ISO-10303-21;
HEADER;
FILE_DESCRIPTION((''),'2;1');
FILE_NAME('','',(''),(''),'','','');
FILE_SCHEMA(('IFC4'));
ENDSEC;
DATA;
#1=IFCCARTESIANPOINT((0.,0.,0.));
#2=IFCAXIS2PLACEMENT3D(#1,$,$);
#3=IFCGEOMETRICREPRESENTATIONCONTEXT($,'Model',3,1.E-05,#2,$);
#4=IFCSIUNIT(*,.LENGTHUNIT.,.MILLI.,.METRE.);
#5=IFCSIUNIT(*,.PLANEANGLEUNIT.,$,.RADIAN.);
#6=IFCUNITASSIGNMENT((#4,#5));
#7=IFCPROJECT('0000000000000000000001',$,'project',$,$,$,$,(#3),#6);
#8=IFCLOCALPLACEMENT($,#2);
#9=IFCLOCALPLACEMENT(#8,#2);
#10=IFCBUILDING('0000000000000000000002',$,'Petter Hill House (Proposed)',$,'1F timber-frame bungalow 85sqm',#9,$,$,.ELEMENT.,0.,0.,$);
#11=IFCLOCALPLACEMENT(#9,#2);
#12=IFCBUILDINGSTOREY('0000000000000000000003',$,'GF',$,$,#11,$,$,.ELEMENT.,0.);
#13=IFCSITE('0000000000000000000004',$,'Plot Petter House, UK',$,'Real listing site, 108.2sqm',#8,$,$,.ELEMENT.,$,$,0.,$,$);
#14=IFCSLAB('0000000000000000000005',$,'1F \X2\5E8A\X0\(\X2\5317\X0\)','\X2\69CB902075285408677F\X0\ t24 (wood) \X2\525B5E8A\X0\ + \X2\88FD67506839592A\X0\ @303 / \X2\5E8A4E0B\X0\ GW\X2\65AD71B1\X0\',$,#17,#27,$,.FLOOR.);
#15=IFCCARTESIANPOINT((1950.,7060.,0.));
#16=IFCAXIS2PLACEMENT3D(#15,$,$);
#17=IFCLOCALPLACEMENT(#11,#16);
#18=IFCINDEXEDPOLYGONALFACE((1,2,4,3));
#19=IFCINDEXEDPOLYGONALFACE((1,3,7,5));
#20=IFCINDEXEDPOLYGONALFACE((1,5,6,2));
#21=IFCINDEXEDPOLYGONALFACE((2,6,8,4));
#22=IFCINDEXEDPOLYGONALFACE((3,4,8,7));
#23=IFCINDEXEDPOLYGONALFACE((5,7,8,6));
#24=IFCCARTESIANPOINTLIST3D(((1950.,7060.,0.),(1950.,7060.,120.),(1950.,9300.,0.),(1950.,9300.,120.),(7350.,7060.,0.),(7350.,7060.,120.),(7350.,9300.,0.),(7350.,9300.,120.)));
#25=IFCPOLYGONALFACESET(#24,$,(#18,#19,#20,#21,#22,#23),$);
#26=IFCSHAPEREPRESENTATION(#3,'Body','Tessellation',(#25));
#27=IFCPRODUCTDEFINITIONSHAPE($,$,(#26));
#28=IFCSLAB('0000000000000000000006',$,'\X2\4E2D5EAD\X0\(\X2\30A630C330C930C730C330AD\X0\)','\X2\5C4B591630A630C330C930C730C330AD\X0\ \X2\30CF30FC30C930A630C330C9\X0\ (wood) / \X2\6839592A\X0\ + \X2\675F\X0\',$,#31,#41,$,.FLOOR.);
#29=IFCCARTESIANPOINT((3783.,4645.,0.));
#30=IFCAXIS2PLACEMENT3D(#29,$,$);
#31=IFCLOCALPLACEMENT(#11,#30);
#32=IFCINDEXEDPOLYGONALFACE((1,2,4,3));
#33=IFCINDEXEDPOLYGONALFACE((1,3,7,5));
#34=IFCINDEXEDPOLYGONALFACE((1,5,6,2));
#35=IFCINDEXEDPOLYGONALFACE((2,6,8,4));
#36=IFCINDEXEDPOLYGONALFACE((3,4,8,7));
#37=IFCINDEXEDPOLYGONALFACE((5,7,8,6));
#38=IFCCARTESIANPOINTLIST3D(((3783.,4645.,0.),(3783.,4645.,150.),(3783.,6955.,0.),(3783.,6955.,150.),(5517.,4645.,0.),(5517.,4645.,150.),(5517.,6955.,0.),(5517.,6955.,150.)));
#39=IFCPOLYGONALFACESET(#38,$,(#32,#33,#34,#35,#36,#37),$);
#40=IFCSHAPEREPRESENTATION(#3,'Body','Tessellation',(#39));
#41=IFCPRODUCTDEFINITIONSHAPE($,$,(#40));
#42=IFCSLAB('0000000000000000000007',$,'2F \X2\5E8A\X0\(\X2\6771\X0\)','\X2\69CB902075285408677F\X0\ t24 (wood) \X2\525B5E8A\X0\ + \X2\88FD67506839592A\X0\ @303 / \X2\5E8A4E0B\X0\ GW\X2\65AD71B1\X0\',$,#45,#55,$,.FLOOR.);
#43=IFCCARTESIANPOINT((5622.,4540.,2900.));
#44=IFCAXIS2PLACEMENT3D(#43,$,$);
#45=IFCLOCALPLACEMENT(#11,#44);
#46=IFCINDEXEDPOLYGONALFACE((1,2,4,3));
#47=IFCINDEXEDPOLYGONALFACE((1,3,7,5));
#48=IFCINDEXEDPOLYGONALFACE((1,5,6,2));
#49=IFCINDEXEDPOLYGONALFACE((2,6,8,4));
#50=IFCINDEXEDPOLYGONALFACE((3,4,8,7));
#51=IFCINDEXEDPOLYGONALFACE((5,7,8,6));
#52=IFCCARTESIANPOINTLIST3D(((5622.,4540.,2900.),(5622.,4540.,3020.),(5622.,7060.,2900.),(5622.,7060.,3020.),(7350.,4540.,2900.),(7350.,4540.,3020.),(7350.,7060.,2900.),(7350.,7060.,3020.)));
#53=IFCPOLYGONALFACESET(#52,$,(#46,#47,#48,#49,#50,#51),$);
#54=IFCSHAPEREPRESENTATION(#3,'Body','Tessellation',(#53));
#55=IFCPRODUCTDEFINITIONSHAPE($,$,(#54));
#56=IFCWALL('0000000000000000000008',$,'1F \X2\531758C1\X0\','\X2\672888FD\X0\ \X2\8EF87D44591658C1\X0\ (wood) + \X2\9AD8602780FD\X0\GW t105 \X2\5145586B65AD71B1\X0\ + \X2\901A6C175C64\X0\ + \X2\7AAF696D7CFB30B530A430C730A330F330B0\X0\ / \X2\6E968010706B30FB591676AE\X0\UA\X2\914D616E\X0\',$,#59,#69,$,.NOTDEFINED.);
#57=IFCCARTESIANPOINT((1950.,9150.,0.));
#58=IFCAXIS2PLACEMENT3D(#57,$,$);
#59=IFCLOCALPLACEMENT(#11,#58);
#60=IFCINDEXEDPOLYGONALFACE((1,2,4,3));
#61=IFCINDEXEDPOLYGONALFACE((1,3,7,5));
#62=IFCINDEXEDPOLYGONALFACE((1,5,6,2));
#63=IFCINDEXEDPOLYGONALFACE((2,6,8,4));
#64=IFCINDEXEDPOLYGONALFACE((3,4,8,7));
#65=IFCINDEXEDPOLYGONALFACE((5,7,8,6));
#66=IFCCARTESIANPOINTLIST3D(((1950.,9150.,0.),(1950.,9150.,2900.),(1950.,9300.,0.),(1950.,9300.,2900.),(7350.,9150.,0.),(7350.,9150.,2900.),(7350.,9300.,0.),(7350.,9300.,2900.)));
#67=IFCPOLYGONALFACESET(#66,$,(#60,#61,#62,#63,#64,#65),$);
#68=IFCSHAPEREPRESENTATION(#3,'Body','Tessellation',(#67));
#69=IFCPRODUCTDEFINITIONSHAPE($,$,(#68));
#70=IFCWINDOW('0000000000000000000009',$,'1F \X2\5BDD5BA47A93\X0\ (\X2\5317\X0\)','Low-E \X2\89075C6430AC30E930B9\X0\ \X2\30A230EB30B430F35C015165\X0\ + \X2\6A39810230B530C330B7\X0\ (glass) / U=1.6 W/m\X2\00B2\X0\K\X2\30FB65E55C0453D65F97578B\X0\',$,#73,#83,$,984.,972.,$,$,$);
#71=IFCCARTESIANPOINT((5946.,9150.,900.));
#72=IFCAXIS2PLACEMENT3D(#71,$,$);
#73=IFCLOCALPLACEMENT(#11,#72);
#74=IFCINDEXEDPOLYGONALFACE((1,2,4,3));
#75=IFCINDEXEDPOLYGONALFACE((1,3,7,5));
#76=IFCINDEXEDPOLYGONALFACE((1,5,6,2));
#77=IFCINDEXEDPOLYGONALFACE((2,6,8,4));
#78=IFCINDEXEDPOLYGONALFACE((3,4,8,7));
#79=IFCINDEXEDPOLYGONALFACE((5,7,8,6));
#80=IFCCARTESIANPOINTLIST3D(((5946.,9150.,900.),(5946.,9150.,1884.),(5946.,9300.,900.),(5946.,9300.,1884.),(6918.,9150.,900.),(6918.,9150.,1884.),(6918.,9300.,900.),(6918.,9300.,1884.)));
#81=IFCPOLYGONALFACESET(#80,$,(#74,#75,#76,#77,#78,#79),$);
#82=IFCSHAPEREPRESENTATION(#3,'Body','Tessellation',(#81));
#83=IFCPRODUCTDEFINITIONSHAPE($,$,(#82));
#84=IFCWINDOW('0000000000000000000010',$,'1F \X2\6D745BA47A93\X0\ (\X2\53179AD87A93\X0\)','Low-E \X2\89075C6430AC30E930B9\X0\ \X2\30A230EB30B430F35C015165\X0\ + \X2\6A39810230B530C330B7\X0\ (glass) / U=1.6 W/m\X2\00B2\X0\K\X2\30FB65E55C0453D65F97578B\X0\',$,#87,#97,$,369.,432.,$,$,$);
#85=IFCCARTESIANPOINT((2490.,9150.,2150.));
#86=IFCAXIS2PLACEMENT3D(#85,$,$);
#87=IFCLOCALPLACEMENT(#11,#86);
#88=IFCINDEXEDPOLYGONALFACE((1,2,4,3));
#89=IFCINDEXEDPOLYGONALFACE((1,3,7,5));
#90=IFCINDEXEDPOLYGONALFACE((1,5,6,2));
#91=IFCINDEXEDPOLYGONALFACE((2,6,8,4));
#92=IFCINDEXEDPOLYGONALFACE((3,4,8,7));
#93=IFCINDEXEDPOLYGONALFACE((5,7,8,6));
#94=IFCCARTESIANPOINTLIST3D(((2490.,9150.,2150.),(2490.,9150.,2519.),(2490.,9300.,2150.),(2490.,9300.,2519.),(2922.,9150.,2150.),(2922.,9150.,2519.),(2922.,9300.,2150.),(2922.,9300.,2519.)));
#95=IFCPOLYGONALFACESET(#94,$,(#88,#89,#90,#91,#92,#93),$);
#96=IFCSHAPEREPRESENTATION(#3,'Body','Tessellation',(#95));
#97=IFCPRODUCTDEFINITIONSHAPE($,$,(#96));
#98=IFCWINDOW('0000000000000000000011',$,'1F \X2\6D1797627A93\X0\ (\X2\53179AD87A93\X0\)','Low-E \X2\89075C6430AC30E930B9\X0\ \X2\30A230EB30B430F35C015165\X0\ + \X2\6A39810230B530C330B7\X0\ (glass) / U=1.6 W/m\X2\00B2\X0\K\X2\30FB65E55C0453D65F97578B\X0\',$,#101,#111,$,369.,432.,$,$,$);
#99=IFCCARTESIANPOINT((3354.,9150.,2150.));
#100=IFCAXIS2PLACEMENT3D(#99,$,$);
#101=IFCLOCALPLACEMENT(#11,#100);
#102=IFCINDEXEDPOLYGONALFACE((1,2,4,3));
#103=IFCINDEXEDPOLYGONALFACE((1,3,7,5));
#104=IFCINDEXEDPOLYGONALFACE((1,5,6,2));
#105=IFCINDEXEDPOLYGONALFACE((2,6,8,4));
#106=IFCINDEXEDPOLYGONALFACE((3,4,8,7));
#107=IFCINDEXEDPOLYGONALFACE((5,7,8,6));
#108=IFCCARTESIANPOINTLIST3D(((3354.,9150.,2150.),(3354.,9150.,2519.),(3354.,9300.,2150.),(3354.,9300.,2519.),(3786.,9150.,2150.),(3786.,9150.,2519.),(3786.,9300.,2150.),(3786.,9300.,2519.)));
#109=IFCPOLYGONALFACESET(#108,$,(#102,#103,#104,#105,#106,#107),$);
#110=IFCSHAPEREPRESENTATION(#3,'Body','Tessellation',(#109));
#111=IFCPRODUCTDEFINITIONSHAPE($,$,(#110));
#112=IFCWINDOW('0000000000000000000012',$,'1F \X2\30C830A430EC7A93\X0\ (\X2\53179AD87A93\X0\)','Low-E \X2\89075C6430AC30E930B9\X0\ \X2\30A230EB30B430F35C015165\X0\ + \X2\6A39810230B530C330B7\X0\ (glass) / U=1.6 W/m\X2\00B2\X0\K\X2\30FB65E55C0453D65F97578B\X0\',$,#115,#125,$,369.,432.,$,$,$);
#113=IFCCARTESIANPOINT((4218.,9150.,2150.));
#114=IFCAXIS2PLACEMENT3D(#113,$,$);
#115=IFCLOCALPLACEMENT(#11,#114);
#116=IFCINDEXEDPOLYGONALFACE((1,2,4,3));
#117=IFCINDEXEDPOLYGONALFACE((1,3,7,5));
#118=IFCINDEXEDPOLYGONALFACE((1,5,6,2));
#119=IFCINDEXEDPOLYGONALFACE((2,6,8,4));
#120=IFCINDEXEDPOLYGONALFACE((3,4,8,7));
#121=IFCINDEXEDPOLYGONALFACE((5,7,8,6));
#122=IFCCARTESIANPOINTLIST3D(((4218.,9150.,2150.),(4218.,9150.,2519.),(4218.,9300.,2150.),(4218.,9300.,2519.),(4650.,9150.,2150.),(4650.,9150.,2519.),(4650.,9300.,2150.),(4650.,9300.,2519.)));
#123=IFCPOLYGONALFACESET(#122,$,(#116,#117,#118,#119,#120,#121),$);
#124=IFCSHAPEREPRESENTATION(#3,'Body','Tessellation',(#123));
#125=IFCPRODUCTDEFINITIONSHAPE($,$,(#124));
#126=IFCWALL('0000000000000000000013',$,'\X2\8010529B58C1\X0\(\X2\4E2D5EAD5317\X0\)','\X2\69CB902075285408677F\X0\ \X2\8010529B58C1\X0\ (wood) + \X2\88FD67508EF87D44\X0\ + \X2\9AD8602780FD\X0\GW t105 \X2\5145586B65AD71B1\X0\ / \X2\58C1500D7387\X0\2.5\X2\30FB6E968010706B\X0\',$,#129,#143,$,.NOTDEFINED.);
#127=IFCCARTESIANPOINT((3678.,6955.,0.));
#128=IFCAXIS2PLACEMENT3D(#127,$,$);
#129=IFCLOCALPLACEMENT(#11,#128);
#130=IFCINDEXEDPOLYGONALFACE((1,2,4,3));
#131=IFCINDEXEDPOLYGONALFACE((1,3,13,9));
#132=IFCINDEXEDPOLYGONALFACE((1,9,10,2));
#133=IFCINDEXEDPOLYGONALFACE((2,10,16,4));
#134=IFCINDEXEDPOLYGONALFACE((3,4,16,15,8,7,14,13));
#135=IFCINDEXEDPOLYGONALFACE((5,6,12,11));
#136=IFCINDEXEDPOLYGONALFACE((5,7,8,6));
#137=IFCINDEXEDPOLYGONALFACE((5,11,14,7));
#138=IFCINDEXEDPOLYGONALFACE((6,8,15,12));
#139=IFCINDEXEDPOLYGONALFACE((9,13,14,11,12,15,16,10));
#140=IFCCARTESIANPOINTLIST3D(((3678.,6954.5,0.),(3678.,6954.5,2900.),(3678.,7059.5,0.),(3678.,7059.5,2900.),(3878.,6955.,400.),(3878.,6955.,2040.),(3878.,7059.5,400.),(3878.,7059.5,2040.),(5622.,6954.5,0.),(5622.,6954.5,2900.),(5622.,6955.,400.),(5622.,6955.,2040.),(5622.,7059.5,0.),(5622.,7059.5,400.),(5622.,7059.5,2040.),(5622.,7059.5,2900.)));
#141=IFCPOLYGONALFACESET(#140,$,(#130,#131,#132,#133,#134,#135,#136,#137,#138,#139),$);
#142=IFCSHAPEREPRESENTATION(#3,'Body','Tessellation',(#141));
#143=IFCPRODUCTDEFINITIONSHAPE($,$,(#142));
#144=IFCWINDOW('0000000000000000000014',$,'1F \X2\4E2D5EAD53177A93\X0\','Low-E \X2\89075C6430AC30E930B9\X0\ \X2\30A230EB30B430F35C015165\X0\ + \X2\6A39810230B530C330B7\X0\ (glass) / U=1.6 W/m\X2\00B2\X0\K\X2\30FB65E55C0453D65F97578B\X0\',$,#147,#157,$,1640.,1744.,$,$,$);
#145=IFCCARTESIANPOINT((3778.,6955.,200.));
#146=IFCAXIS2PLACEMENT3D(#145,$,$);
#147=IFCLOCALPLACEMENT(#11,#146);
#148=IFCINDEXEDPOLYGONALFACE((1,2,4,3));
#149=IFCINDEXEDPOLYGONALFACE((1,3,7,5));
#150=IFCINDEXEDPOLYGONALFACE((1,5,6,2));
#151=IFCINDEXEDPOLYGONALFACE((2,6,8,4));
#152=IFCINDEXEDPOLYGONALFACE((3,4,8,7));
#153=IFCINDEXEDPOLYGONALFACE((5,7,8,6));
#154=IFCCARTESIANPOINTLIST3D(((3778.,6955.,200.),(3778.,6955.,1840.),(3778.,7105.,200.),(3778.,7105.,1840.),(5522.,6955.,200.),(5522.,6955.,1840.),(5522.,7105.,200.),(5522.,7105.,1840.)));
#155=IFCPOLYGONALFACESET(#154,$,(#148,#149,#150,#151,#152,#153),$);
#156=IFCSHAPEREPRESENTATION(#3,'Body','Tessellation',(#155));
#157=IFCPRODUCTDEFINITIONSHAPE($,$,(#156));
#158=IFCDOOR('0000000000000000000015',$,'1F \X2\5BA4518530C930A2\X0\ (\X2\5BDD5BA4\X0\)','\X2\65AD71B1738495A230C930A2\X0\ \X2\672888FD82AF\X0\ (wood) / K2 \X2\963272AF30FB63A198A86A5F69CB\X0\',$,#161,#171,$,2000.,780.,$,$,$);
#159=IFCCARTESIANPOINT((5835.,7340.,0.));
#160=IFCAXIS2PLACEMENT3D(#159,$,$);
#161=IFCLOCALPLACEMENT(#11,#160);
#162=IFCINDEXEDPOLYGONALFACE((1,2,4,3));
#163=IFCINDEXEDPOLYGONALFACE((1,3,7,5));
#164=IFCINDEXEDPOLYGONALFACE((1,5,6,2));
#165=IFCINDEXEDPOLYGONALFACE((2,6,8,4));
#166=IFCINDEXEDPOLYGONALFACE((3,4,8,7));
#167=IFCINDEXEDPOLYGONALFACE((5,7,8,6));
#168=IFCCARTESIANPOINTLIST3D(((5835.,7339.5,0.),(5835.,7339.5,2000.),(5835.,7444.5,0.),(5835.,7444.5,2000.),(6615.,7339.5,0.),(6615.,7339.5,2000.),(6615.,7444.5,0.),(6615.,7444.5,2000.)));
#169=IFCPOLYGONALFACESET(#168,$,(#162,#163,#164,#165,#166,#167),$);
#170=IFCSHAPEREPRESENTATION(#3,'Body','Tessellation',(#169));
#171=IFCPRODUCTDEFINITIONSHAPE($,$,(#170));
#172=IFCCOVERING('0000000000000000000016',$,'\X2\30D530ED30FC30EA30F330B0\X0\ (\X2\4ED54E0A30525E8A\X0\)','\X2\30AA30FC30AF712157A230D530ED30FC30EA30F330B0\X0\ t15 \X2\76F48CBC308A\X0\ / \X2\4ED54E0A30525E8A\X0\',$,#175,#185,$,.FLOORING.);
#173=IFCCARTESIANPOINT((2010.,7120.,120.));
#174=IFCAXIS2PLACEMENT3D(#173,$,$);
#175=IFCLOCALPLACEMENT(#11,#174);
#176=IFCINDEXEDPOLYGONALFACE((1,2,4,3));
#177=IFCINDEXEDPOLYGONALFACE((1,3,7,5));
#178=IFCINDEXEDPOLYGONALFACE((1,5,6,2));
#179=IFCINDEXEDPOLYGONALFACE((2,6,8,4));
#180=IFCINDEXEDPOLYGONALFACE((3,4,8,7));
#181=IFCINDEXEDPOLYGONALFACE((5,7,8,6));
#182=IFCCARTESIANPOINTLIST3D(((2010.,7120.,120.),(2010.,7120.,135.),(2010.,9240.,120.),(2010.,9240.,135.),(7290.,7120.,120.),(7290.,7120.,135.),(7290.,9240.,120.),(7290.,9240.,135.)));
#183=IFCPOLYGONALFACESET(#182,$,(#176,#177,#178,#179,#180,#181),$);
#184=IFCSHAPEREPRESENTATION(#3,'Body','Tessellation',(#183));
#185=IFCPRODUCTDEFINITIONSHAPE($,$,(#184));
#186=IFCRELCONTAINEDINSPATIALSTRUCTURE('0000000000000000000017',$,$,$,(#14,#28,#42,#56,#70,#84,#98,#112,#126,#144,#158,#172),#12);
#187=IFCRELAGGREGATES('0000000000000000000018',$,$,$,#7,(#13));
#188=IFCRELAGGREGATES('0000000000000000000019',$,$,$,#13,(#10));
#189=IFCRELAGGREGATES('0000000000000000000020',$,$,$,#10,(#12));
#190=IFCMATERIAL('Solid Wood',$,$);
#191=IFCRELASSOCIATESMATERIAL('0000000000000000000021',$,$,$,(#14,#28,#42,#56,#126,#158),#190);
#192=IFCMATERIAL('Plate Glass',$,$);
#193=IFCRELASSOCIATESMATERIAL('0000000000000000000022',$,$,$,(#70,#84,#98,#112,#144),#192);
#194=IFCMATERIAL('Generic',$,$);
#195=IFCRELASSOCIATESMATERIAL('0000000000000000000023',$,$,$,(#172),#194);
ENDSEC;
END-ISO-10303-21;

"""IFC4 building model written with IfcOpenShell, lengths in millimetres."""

from ifc_helpers import new_model, si_unit, frame, frame_2d, origin, place, context, project, spatial, rectangle, extrude, material, element, fill, save


model = new_model("IFC4")

# Units and contexts
model_context = context("Model", 3, precision=1e-05, world=origin())
ifc_project = project(units=[si_unit("LENGTHUNIT", "METRE", prefix="MILLI"), si_unit("PLANEANGLEUNIT", "RADIAN")], contexts=[model_context])

# Site, building, storey
site_placement = place(None, origin())
site = spatial("IfcSite", under=ifc_project, at=site_placement, Name="Plot Petter House, UK", ObjectType="Real listing site, 108.2sqm", CompositionType="ELEMENT", RefElevation=0.0)
building_placement = place(site_placement, origin())
building = spatial("IfcBuilding", under=site, at=building_placement, Name="Petter Hill House (Proposed)", ObjectType="1F timber-frame bungalow 85sqm", CompositionType="ELEMENT", ElevationOfRefHeight=0.0, ElevationOfTerrain=0.0)
storey_placement = place(building_placement, origin())
storey = spatial("IfcBuildingStorey", under=building, at=storey_placement, Name="GF", CompositionType="ELEMENT", Elevation=0.0)

# Slabs
ifc_material_1 = material(Name="Solid Wood")
slab_1_placement = place(storey_placement, frame((1950.0, 7060.0, 0.0)))
element("IfcSlab", 1, at=slab_1_placement, inside=storey, material=ifc_material_1, Name="1F 床(北)", Description="構造用合板 t24 (wood) 剛床 + 製材根太 @303 / 床下 GW断熱", PredefinedType="FLOOR", context=model_context, shape_type="SweptSolid", body=[
    extrude(rectangle(XDim=5400.0, YDim=2240.0, at=frame_2d((2700.0, 1120.0))), frame((1950.0, 7060.0, 0.0)), (0.0, 0.0, 1.0), 120.0),
])
slab_2_placement = place(storey_placement, frame((3783.0, 4645.0, 0.0)))
element("IfcSlab", 2, at=slab_2_placement, inside=storey, material=ifc_material_1, Name="中庭(ウッドデッキ)", Description="屋外ウッドデッキ ハードウッド (wood) / 根太 + 束", PredefinedType="FLOOR", context=model_context, shape_type="SweptSolid", body=[
    extrude(rectangle(XDim=1734.0, YDim=2310.0, at=frame_2d((867.0, 1155.0))), frame((3783.0, 4645.0, 0.0)), (0.0, 0.0, 1.0), 150.0),
])
slab_3_placement = place(storey_placement, frame((5622.0, 4540.0, 2900.0)))
element("IfcSlab", 3, at=slab_3_placement, inside=storey, material=ifc_material_1, Name="2F 床(東)", Description="構造用合板 t24 (wood) 剛床 + 製材根太 @303 / 床下 GW断熱", PredefinedType="FLOOR", context=model_context, shape_type="SweptSolid", body=[
    extrude(rectangle(XDim=1728.0, YDim=2520.0, at=frame_2d((864.0, 1260.0))), frame((5622.0, 4540.0, 2900.0)), (0.0, 0.0, 1.0), 120.0),
])

# Wall, openings, windows
wall_1_placement = place(storey_placement, frame((1950.0, 9150.0, 0.0)))
wall_1 = element("IfcWall", 4, at=wall_1_placement, inside=storey, material=ifc_material_1, Name="1F 北壁", Description="木製 軸組外壁 (wood) + 高性能GW t105 充填断熱 + 通気層 + 窯業系サイディング / 準耐火・外皮UA配慮", PredefinedType="NOTDEFINED", context=model_context, shape_type="SweptSolid", body=[
    extrude(rectangle(XDim=5400.0, YDim=150.0, at=frame_2d((2700.0, 75.0))), frame((1950.0, 9150.0, 0.0)), (0.0, 0.0, 1.0), 2900.0),
])
opening_1_placement = place(storey_placement, frame((5946.0, 9150.0, 900.0)))
opening_1 = element("IfcOpeningElement", 5, at=opening_1_placement, cuts=wall_1, PredefinedType="NOTDEFINED", context=model_context, shape_type="SweptSolid", body=[
    extrude(rectangle(XDim=972.0, YDim=150.0, at=frame_2d((486.0, 75.0))), frame((5946.0, 9150.0, 900.0)), (0.0, 0.0, 1.0), 984.0),
])
opening_2_placement = place(storey_placement, frame((2490.0, 9150.0, 2150.0)))
opening_2 = element("IfcOpeningElement", 6, at=opening_2_placement, cuts=wall_1, PredefinedType="NOTDEFINED", context=model_context, shape_type="SweptSolid", body=[
    extrude(rectangle(XDim=432.0, YDim=150.0, at=frame_2d((216.0, 75.0))), frame((2490.0, 9150.0, 2150.0)), (0.0, 0.0, 1.0), 369.0),
])
opening_3_placement = place(storey_placement, frame((3354.0, 9150.0, 2150.0)))
opening_3 = element("IfcOpeningElement", 7, at=opening_3_placement, cuts=wall_1, PredefinedType="NOTDEFINED", context=model_context, shape_type="SweptSolid", body=[
    extrude(rectangle(XDim=432.0, YDim=150.0, at=frame_2d((216.0, 75.0))), frame((3354.0, 9150.0, 2150.0)), (0.0, 0.0, 1.0), 369.0),
])
opening_4_placement = place(storey_placement, frame((4218.0, 9150.0, 2150.0)))
opening_4 = element("IfcOpeningElement", 8, at=opening_4_placement, cuts=wall_1, PredefinedType="NOTDEFINED", context=model_context, shape_type="SweptSolid", body=[
    extrude(rectangle(XDim=432.0, YDim=150.0, at=frame_2d((216.0, 75.0))), frame((4218.0, 9150.0, 2150.0)), (0.0, 0.0, 1.0), 369.0),
])
ifc_material_2 = material(Name="Plate Glass")
window_1_placement = place(storey_placement, frame((5946.0, 9150.0, 900.0)))
window_1 = element("IfcWindow", 9, at=window_1_placement, inside=storey, material=ifc_material_2, Name="1F 寝室窓 (北)", Description="Low-E 複層ガラス アルゴン封入 + 樹脂サッシ (glass) / U=1.6 W/m²K・日射取得型", OverallHeight=984.0, OverallWidth=972.0, context=model_context, shape_type="SweptSolid", body=[
    extrude(rectangle(XDim=972.0, YDim=150.0, at=frame_2d((486.0, 75.0))), frame((5946.0, 9150.0, 900.0)), (0.0, 0.0, 1.0), 984.0),
])
fill(opening_1, window_1)
window_2_placement = place(storey_placement, frame((2490.0, 9150.0, 2150.0)))
window_2 = element("IfcWindow", 10, at=window_2_placement, inside=storey, material=ifc_material_2, Name="1F 浴室窓 (北高窓)", Description="Low-E 複層ガラス アルゴン封入 + 樹脂サッシ (glass) / U=1.6 W/m²K・日射取得型", OverallHeight=369.0, OverallWidth=432.0, context=model_context, shape_type="SweptSolid", body=[
    extrude(rectangle(XDim=432.0, YDim=150.0, at=frame_2d((216.0, 75.0))), frame((2490.0, 9150.0, 2150.0)), (0.0, 0.0, 1.0), 369.0),
])
fill(opening_2, window_2)
window_3_placement = place(storey_placement, frame((3354.0, 9150.0, 2150.0)))
window_3 = element("IfcWindow", 11, at=window_3_placement, inside=storey, material=ifc_material_2, Name="1F 洗面窓 (北高窓)", Description="Low-E 複層ガラス アルゴン封入 + 樹脂サッシ (glass) / U=1.6 W/m²K・日射取得型", OverallHeight=369.0, OverallWidth=432.0, context=model_context, shape_type="SweptSolid", body=[
    extrude(rectangle(XDim=432.0, YDim=150.0, at=frame_2d((216.0, 75.0))), frame((3354.0, 9150.0, 2150.0)), (0.0, 0.0, 1.0), 369.0),
])
fill(opening_3, window_3)
window_4_placement = place(storey_placement, frame((4218.0, 9150.0, 2150.0)))
window_4 = element("IfcWindow", 12, at=window_4_placement, inside=storey, material=ifc_material_2, Name="1F トイレ窓 (北高窓)", Description="Low-E 複層ガラス アルゴン封入 + 樹脂サッシ (glass) / U=1.6 W/m²K・日射取得型", OverallHeight=369.0, OverallWidth=432.0, context=model_context, shape_type="SweptSolid", body=[
    extrude(rectangle(XDim=432.0, YDim=150.0, at=frame_2d((216.0, 75.0))), frame((4218.0, 9150.0, 2150.0)), (0.0, 0.0, 1.0), 369.0),
])
fill(opening_4, window_4)

# Wall, opening, window
wall_2_placement = place(storey_placement, frame((3678.0, 6955.0, 0.0)))
wall_2 = element("IfcWall", 13, at=wall_2_placement, inside=storey, material=ifc_material_1, Name="耐力壁(中庭北)", Description="構造用合板 耐力壁 (wood) + 製材軸組 + 高性能GW t105 充填断熱 / 壁倍率2.5・準耐火", PredefinedType="NOTDEFINED", context=model_context, shape_type="SweptSolid", body=[
    extrude(rectangle(XDim=1944.0, YDim=105.0, at=frame_2d((972.0, 52.0))), frame((3678.0, 6955.0, 0.0)), (0.0, 0.0, 1.0), 2900.0),
])
opening_5_placement = place(storey_placement, frame((3778.0, 6955.0, 200.0)))
opening_5 = element("IfcOpeningElement", 14, at=opening_5_placement, cuts=wall_2, PredefinedType="NOTDEFINED", context=model_context, shape_type="SweptSolid", body=[
    extrude(rectangle(XDim=1744.0, YDim=150.0, at=frame_2d((872.0, 75.0))), frame((3778.0, 6955.0, 200.0)), (0.0, 0.0, 1.0), 1640.0),
])
window_5_placement = place(storey_placement, frame((3778.0, 6955.0, 200.0)))
window_5 = element("IfcWindow", 15, at=window_5_placement, inside=storey, material=ifc_material_2, Name="1F 中庭北窓", Description="Low-E 複層ガラス アルゴン封入 + 樹脂サッシ (glass) / U=1.6 W/m²K・日射取得型", OverallHeight=1640.0, OverallWidth=1744.0, context=model_context, shape_type="SweptSolid", body=[
    extrude(rectangle(XDim=1744.0, YDim=150.0, at=frame_2d((872.0, 75.0))), frame((3778.0, 6955.0, 200.0)), (0.0, 0.0, 1.0), 1640.0),
])
fill(opening_5, window_5)

# Door
door_1_placement = place(storey_placement, frame((5835.0, 7340.0, 0.0)))
element("IfcDoor", 16, at=door_1_placement, inside=storey, material=ifc_material_1, Name="1F 室内ドア (寝室)", Description="断熱玄関ドア 木製芯 (wood) / K2 防犯・採風機構", OverallHeight=2000.0, OverallWidth=780.0, context=model_context, shape_type="SweptSolid", body=[
    extrude(rectangle(XDim=780.0, YDim=105.0, at=frame_2d((390.0, 52.0))), frame((5835.0, 7340.0, 0.0)), (0.0, 0.0, 1.0), 2000.0),
])

# Covering
ifc_material_3 = material(Name="Generic")
covering_1_placement = place(storey_placement, frame((2010.0, 7120.0, 120.0)))
element("IfcCovering", 17, at=covering_1_placement, inside=storey, material=ifc_material_3, Name="フローリング (仕上げ床)", Description="オーク無垢フローリング t15 直貼り / 仕上げ床", PredefinedType="FLOORING", context=model_context, shape_type="SweptSolid", body=[
    extrude(rectangle(XDim=5280.0, YDim=2120.0, at=frame_2d((2640.0, 1060.0))), frame((2010.0, 7120.0, 120.0)), (0.0, 0.0, 1.0), 15.0),
])

save(model, "model.ifc")
